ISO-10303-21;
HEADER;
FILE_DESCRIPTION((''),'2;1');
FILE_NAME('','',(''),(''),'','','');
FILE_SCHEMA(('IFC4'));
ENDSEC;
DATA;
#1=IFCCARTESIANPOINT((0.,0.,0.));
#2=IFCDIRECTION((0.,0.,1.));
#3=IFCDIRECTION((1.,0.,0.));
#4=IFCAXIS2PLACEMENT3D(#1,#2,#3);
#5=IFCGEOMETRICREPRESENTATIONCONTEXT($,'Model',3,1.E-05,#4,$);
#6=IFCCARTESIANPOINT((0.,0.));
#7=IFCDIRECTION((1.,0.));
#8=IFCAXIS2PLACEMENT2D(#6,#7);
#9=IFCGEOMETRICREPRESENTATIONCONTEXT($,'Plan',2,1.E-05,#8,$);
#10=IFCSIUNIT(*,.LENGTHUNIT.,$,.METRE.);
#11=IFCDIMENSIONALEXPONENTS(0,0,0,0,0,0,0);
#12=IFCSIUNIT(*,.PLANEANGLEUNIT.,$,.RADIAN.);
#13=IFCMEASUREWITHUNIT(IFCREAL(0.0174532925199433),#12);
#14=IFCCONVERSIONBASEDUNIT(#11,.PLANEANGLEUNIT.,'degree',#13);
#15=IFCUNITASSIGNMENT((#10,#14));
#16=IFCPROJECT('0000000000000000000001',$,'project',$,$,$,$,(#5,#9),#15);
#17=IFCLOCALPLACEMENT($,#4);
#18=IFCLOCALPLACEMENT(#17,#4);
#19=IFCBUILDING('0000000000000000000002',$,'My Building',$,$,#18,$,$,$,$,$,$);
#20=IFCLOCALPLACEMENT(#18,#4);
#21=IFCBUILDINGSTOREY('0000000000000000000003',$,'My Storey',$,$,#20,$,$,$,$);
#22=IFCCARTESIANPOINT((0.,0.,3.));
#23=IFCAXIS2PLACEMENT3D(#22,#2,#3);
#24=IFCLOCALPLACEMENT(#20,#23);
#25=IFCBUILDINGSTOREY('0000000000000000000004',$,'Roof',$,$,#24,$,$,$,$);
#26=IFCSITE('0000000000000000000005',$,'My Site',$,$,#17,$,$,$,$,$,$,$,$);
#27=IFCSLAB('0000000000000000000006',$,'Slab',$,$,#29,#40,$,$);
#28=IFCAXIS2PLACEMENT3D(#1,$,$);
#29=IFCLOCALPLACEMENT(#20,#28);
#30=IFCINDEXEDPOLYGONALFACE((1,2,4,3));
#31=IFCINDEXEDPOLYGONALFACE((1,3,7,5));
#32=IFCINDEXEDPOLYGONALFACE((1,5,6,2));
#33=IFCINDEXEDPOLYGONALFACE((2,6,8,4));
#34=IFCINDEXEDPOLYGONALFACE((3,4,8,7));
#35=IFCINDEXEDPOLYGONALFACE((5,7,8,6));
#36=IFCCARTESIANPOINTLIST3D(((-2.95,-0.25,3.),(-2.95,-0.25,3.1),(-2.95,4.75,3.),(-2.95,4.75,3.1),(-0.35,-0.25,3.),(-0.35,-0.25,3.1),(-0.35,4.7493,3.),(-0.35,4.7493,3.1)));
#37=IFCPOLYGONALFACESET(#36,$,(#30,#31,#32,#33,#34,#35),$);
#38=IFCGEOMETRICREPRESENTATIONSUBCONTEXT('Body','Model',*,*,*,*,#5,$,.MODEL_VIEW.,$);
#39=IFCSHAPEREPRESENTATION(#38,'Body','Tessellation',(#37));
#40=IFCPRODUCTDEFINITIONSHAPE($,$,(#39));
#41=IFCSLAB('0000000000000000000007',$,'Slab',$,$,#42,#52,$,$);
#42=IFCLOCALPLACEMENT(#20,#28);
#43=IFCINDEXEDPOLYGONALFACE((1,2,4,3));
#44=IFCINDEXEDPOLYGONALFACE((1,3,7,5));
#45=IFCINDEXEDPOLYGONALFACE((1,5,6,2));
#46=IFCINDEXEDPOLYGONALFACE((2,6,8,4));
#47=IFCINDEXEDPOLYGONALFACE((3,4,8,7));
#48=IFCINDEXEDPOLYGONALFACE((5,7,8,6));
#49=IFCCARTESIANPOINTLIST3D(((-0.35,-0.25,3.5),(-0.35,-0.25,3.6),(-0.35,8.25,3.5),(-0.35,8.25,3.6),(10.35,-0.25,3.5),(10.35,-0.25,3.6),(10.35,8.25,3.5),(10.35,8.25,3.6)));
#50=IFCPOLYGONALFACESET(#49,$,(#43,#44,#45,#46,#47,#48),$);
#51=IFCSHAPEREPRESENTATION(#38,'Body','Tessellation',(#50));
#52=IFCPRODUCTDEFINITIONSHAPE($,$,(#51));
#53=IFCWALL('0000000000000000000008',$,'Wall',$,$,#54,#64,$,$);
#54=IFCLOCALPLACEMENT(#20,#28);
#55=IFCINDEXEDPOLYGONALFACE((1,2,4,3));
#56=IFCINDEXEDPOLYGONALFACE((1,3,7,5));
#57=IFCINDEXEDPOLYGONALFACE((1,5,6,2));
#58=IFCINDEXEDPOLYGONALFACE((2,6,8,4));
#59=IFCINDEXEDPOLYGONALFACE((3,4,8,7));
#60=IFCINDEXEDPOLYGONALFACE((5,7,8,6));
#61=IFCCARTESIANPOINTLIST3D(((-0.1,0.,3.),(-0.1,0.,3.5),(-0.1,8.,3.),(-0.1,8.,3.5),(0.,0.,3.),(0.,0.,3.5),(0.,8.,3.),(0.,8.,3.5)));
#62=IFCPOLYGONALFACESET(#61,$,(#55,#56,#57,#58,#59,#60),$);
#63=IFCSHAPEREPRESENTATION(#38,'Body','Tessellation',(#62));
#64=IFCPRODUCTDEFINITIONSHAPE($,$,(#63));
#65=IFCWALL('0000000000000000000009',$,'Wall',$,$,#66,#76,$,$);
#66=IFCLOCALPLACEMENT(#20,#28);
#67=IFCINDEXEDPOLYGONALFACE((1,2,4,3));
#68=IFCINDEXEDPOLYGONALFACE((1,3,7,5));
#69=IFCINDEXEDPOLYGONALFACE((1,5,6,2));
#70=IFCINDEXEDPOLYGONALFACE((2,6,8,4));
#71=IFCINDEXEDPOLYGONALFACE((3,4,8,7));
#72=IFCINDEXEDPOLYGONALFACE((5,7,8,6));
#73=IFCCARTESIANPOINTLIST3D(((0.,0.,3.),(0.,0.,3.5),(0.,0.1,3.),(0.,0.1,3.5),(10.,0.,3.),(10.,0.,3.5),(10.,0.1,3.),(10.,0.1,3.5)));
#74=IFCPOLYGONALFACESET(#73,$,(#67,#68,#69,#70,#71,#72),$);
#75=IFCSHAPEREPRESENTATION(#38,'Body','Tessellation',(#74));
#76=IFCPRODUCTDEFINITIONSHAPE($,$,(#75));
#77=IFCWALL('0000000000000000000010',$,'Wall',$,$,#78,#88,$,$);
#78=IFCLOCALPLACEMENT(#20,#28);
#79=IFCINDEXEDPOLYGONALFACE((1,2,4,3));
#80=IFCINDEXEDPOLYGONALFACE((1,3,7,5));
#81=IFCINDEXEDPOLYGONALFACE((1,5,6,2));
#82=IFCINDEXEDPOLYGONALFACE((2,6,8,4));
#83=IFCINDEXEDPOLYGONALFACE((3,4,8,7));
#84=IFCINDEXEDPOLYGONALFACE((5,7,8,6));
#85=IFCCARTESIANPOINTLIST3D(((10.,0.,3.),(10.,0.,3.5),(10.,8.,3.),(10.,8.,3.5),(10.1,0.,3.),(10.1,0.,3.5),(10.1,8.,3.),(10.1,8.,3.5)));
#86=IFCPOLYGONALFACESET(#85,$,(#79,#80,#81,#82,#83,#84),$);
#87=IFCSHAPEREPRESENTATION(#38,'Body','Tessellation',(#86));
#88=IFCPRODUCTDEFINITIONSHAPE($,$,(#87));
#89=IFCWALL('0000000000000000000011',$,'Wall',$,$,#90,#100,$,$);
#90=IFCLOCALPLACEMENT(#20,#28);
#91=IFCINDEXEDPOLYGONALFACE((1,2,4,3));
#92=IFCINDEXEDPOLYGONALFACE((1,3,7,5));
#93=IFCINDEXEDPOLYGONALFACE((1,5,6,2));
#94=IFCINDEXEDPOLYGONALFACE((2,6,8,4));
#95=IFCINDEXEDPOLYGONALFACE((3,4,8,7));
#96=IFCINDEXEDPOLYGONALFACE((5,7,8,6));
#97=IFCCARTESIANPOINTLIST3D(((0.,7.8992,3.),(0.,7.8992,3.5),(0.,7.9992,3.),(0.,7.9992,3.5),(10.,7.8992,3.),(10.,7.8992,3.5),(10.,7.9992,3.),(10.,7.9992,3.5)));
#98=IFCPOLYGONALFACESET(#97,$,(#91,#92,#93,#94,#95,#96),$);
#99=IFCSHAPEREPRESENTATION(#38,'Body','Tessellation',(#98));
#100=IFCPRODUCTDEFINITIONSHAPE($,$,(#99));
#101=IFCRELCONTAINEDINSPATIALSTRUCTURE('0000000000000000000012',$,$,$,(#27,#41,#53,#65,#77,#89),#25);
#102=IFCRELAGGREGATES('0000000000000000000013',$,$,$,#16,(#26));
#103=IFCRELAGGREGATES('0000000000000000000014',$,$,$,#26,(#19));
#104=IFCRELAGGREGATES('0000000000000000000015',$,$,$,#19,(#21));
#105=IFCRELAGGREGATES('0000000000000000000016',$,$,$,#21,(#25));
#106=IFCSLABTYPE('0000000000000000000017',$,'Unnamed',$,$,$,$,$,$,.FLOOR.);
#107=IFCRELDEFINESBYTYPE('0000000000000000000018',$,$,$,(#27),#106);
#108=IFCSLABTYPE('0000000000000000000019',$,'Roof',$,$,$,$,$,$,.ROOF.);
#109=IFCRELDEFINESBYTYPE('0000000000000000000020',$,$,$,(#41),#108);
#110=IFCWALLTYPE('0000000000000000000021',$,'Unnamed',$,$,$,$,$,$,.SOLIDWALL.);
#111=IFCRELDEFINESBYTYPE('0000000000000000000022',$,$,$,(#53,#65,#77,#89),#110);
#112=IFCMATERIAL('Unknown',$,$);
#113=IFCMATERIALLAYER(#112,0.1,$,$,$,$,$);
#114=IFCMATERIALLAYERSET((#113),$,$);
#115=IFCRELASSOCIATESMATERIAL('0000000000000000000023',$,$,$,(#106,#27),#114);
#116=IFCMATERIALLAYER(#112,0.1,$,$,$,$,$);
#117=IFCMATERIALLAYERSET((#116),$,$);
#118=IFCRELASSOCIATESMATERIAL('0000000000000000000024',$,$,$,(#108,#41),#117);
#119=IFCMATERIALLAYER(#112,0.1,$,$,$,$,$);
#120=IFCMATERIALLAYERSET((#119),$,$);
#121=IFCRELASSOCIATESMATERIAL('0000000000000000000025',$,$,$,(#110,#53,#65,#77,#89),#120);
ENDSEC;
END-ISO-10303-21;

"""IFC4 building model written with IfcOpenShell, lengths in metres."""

from ifc_helpers import new_model, entity, si_unit, converted_unit, frame, origin_with_axes, origin_2d_with_axis, place, context, subcontext, project, spatial, line, indexed_curve, outline, extrude, material, layer, layer_set, layer_usage, type_object, element, save


model = new_model("IFC4")

# Units and contexts
model_context = context("Model", 3, precision=1e-05, world=origin_with_axes())
plan_context = context("Plan", 2, precision=1e-05, world=origin_2d_with_axis())
body_context = subcontext(model_context, "Body", "Model", "MODEL_VIEW")
ifc_project = project(units=[si_unit("LENGTHUNIT", "METRE"), converted_unit("PLANEANGLEUNIT", "degree", entity("IfcReal", 0.0174532925199433), si_unit("PLANEANGLEUNIT", "RADIAN"), dimensions=[0, 0, 0, 0, 0, 0, 0])], contexts=[model_context, plan_context])

# Site, building, storeys
site_placement = place(None, origin_with_axes())
site = spatial("IfcSite", under=ifc_project, at=site_placement, Name="My Site")
building_placement = place(site_placement, origin_with_axes())
building = spatial("IfcBuilding", under=site, at=building_placement, Name="My Building")
storey_1_placement = place(building_placement, origin_with_axes())
storey_1 = spatial("IfcBuildingStorey", under=building, at=storey_1_placement, Name="My Storey")
storey_2_placement = place(storey_1_placement, frame((0.0, 0.0, 3.0), z_axis=(0.0, 0.0, 1.0), x_axis=(1.0, 0.0, 0.0)))
storey_2 = spatial("IfcBuildingStorey", under=storey_1, at=storey_2_placement, Name="Roof")

# Slabs
ifc_material = material(Name="Unknown")
ifc_layer_1 = layer(ifc_material, 0.1)
ifc_layer_set_1 = layer_set([ifc_layer_1])
ifc_layer_usage_1 = layer_usage(ifc_layer_set_1, "AXIS3", "POSITIVE", -0.1)
slab_type_1 = type_object("IfcSlabType", Name="Unnamed", PredefinedType="FLOOR", material=ifc_layer_set_1)
slab_1_placement = place(storey_2_placement, frame((-2.95, 4.75, 0.1), z_axis=(0.0, 0.0, 1.0), x_axis=(1.0, 0.0, 0.0)))
element("IfcSlab", 1, at=slab_1_placement, inside=storey_2, type_object=slab_type_1, material=ifc_layer_usage_1, Name="Slab", context=body_context, shape_type="SweptSolid", body=[
    extrude(outline(indexed_curve([(0.0, 0.0), (0.0, -5.0), (2.6, -5.0), (2.6, -0.0007), (0.0, 0.0)])), frame((0.0, 0.0, -0.1), z_axis=(0.0, 0.0, 1.0), x_axis=(1.0, 0.0, 0.0)), (0.0, 0.0, 1.0), 0.1),
])
ifc_layer_2 = layer(ifc_material, 0.1)
ifc_layer_set_2 = layer_set([ifc_layer_2])
ifc_layer_usage_2 = layer_usage(ifc_layer_set_2, "AXIS3", "POSITIVE", -0.1)
slab_type_2 = type_object("IfcSlabType", Name="Roof", PredefinedType="ROOF", material=ifc_layer_set_2)
slab_2_placement = place(storey_2_placement, frame((-0.35, 8.25, 0.6), z_axis=(0.0, 0.0, 1.0), x_axis=(1.0, 0.0, 0.0)))
element("IfcSlab", 2, at=slab_2_placement, inside=storey_2, type_object=slab_type_2, material=ifc_layer_usage_2, Name="Slab", context=body_context, shape_type="SweptSolid", body=[
    extrude(outline(indexed_curve([(0.0, 0.0), (0.0, -8.5), (10.7, -8.5), (10.7, 0.0), (0.0, 0.0)])), frame((0.0, 0.0, -0.1), z_axis=(0.0, 0.0, 1.0), x_axis=(1.0, 0.0, 0.0)), (0.0, 0.0, 1.0), 0.1),
])

# Walls
ifc_layer_3 = layer(ifc_material, 0.1)
ifc_layer_set_3 = layer_set([ifc_layer_3])
ifc_layer_usage_3 = layer_usage(ifc_layer_set_3, "AXIS2", "POSITIVE", 0.0)
wall_type = type_object("IfcWallType", Name="Unnamed", PredefinedType="SOLIDWALL", material=ifc_layer_set_3)
wall_1_placement = place(storey_2_placement, frame((0.0, 0.0, 0.0), z_axis=(0.0, 0.0, 1.0), x_axis=(0.0, 1.0, 0.0)))
element("IfcWall", 3, at=wall_1_placement, inside=storey_2, type_object=wall_type, material=ifc_layer_usage_3, Name="Wall", context=body_context, shape_type="SweptSolid", body=[
    extrude(outline(indexed_curve([(0.0, 0.0), (0.0, 0.1), (8.0, 0.1), (8.0, 0.0)], segments=[line(1, 2, 3, 4, 1)])), origin_with_axes(), (0.0, 0.0, 1.0), 0.5),
])
ifc_layer_usage_4 = layer_usage(ifc_layer_set_3, "AXIS2", "POSITIVE", 0.0)
wall_2_placement = place(storey_2_placement, origin_with_axes())
element("IfcWall", 4, at=wall_2_placement, inside=storey_2, type_object=wall_type, material=ifc_layer_usage_4, Name="Wall", context=body_context, shape_type="SweptSolid", body=[
    extrude(outline(indexed_curve([(0.0, 0.0), (0.0, 0.1), (10.0, 0.1), (10.0, 0.0)], segments=[line(1, 2, 3, 4, 1)])), origin_with_axes(), (0.0, 0.0, 1.0), 0.5),
])
ifc_layer_usage_5 = layer_usage(ifc_layer_set_3, "AXIS2", "POSITIVE", 0.0)
wall_3_placement = place(storey_2_placement, frame((10.1, 0.0, 0.0), z_axis=(0.0, 0.0, 1.0), x_axis=(0.0, 1.0, 0.0)))
element("IfcWall", 5, at=wall_3_placement, inside=storey_2, type_object=wall_type, material=ifc_layer_usage_5, Name="Wall", context=body_context, shape_type="SweptSolid", body=[
    extrude(outline(indexed_curve([(0.0, 0.0), (0.0, 0.1), (8.0, 0.1), (8.0, 0.0)], segments=[line(1, 2, 3, 4, 1)])), origin_with_axes(), (0.0, 0.0, 1.0), 0.5),
])
ifc_layer_usage_6 = layer_usage(ifc_layer_set_3, "AXIS2", "POSITIVE", 0.0)
wall_4_placement = place(storey_2_placement, frame((0.0, 7.8992, 0.0), z_axis=(0.0, 0.0, 1.0), x_axis=(1.0, 0.0, 0.0)))
element("IfcWall", 6, at=wall_4_placement, inside=storey_2, type_object=wall_type, material=ifc_layer_usage_6, Name="Wall", context=body_context, shape_type="SweptSolid", body=[
    extrude(outline(indexed_curve([(0.0, 0.0), (0.0, 0.1), (10.0, 0.1), (10.0, 0.0)], segments=[line(1, 2, 3, 4, 1)])), origin_with_axes(), (0.0, 0.0, 1.0), 0.5),
])

save(model, "model.ifc")
